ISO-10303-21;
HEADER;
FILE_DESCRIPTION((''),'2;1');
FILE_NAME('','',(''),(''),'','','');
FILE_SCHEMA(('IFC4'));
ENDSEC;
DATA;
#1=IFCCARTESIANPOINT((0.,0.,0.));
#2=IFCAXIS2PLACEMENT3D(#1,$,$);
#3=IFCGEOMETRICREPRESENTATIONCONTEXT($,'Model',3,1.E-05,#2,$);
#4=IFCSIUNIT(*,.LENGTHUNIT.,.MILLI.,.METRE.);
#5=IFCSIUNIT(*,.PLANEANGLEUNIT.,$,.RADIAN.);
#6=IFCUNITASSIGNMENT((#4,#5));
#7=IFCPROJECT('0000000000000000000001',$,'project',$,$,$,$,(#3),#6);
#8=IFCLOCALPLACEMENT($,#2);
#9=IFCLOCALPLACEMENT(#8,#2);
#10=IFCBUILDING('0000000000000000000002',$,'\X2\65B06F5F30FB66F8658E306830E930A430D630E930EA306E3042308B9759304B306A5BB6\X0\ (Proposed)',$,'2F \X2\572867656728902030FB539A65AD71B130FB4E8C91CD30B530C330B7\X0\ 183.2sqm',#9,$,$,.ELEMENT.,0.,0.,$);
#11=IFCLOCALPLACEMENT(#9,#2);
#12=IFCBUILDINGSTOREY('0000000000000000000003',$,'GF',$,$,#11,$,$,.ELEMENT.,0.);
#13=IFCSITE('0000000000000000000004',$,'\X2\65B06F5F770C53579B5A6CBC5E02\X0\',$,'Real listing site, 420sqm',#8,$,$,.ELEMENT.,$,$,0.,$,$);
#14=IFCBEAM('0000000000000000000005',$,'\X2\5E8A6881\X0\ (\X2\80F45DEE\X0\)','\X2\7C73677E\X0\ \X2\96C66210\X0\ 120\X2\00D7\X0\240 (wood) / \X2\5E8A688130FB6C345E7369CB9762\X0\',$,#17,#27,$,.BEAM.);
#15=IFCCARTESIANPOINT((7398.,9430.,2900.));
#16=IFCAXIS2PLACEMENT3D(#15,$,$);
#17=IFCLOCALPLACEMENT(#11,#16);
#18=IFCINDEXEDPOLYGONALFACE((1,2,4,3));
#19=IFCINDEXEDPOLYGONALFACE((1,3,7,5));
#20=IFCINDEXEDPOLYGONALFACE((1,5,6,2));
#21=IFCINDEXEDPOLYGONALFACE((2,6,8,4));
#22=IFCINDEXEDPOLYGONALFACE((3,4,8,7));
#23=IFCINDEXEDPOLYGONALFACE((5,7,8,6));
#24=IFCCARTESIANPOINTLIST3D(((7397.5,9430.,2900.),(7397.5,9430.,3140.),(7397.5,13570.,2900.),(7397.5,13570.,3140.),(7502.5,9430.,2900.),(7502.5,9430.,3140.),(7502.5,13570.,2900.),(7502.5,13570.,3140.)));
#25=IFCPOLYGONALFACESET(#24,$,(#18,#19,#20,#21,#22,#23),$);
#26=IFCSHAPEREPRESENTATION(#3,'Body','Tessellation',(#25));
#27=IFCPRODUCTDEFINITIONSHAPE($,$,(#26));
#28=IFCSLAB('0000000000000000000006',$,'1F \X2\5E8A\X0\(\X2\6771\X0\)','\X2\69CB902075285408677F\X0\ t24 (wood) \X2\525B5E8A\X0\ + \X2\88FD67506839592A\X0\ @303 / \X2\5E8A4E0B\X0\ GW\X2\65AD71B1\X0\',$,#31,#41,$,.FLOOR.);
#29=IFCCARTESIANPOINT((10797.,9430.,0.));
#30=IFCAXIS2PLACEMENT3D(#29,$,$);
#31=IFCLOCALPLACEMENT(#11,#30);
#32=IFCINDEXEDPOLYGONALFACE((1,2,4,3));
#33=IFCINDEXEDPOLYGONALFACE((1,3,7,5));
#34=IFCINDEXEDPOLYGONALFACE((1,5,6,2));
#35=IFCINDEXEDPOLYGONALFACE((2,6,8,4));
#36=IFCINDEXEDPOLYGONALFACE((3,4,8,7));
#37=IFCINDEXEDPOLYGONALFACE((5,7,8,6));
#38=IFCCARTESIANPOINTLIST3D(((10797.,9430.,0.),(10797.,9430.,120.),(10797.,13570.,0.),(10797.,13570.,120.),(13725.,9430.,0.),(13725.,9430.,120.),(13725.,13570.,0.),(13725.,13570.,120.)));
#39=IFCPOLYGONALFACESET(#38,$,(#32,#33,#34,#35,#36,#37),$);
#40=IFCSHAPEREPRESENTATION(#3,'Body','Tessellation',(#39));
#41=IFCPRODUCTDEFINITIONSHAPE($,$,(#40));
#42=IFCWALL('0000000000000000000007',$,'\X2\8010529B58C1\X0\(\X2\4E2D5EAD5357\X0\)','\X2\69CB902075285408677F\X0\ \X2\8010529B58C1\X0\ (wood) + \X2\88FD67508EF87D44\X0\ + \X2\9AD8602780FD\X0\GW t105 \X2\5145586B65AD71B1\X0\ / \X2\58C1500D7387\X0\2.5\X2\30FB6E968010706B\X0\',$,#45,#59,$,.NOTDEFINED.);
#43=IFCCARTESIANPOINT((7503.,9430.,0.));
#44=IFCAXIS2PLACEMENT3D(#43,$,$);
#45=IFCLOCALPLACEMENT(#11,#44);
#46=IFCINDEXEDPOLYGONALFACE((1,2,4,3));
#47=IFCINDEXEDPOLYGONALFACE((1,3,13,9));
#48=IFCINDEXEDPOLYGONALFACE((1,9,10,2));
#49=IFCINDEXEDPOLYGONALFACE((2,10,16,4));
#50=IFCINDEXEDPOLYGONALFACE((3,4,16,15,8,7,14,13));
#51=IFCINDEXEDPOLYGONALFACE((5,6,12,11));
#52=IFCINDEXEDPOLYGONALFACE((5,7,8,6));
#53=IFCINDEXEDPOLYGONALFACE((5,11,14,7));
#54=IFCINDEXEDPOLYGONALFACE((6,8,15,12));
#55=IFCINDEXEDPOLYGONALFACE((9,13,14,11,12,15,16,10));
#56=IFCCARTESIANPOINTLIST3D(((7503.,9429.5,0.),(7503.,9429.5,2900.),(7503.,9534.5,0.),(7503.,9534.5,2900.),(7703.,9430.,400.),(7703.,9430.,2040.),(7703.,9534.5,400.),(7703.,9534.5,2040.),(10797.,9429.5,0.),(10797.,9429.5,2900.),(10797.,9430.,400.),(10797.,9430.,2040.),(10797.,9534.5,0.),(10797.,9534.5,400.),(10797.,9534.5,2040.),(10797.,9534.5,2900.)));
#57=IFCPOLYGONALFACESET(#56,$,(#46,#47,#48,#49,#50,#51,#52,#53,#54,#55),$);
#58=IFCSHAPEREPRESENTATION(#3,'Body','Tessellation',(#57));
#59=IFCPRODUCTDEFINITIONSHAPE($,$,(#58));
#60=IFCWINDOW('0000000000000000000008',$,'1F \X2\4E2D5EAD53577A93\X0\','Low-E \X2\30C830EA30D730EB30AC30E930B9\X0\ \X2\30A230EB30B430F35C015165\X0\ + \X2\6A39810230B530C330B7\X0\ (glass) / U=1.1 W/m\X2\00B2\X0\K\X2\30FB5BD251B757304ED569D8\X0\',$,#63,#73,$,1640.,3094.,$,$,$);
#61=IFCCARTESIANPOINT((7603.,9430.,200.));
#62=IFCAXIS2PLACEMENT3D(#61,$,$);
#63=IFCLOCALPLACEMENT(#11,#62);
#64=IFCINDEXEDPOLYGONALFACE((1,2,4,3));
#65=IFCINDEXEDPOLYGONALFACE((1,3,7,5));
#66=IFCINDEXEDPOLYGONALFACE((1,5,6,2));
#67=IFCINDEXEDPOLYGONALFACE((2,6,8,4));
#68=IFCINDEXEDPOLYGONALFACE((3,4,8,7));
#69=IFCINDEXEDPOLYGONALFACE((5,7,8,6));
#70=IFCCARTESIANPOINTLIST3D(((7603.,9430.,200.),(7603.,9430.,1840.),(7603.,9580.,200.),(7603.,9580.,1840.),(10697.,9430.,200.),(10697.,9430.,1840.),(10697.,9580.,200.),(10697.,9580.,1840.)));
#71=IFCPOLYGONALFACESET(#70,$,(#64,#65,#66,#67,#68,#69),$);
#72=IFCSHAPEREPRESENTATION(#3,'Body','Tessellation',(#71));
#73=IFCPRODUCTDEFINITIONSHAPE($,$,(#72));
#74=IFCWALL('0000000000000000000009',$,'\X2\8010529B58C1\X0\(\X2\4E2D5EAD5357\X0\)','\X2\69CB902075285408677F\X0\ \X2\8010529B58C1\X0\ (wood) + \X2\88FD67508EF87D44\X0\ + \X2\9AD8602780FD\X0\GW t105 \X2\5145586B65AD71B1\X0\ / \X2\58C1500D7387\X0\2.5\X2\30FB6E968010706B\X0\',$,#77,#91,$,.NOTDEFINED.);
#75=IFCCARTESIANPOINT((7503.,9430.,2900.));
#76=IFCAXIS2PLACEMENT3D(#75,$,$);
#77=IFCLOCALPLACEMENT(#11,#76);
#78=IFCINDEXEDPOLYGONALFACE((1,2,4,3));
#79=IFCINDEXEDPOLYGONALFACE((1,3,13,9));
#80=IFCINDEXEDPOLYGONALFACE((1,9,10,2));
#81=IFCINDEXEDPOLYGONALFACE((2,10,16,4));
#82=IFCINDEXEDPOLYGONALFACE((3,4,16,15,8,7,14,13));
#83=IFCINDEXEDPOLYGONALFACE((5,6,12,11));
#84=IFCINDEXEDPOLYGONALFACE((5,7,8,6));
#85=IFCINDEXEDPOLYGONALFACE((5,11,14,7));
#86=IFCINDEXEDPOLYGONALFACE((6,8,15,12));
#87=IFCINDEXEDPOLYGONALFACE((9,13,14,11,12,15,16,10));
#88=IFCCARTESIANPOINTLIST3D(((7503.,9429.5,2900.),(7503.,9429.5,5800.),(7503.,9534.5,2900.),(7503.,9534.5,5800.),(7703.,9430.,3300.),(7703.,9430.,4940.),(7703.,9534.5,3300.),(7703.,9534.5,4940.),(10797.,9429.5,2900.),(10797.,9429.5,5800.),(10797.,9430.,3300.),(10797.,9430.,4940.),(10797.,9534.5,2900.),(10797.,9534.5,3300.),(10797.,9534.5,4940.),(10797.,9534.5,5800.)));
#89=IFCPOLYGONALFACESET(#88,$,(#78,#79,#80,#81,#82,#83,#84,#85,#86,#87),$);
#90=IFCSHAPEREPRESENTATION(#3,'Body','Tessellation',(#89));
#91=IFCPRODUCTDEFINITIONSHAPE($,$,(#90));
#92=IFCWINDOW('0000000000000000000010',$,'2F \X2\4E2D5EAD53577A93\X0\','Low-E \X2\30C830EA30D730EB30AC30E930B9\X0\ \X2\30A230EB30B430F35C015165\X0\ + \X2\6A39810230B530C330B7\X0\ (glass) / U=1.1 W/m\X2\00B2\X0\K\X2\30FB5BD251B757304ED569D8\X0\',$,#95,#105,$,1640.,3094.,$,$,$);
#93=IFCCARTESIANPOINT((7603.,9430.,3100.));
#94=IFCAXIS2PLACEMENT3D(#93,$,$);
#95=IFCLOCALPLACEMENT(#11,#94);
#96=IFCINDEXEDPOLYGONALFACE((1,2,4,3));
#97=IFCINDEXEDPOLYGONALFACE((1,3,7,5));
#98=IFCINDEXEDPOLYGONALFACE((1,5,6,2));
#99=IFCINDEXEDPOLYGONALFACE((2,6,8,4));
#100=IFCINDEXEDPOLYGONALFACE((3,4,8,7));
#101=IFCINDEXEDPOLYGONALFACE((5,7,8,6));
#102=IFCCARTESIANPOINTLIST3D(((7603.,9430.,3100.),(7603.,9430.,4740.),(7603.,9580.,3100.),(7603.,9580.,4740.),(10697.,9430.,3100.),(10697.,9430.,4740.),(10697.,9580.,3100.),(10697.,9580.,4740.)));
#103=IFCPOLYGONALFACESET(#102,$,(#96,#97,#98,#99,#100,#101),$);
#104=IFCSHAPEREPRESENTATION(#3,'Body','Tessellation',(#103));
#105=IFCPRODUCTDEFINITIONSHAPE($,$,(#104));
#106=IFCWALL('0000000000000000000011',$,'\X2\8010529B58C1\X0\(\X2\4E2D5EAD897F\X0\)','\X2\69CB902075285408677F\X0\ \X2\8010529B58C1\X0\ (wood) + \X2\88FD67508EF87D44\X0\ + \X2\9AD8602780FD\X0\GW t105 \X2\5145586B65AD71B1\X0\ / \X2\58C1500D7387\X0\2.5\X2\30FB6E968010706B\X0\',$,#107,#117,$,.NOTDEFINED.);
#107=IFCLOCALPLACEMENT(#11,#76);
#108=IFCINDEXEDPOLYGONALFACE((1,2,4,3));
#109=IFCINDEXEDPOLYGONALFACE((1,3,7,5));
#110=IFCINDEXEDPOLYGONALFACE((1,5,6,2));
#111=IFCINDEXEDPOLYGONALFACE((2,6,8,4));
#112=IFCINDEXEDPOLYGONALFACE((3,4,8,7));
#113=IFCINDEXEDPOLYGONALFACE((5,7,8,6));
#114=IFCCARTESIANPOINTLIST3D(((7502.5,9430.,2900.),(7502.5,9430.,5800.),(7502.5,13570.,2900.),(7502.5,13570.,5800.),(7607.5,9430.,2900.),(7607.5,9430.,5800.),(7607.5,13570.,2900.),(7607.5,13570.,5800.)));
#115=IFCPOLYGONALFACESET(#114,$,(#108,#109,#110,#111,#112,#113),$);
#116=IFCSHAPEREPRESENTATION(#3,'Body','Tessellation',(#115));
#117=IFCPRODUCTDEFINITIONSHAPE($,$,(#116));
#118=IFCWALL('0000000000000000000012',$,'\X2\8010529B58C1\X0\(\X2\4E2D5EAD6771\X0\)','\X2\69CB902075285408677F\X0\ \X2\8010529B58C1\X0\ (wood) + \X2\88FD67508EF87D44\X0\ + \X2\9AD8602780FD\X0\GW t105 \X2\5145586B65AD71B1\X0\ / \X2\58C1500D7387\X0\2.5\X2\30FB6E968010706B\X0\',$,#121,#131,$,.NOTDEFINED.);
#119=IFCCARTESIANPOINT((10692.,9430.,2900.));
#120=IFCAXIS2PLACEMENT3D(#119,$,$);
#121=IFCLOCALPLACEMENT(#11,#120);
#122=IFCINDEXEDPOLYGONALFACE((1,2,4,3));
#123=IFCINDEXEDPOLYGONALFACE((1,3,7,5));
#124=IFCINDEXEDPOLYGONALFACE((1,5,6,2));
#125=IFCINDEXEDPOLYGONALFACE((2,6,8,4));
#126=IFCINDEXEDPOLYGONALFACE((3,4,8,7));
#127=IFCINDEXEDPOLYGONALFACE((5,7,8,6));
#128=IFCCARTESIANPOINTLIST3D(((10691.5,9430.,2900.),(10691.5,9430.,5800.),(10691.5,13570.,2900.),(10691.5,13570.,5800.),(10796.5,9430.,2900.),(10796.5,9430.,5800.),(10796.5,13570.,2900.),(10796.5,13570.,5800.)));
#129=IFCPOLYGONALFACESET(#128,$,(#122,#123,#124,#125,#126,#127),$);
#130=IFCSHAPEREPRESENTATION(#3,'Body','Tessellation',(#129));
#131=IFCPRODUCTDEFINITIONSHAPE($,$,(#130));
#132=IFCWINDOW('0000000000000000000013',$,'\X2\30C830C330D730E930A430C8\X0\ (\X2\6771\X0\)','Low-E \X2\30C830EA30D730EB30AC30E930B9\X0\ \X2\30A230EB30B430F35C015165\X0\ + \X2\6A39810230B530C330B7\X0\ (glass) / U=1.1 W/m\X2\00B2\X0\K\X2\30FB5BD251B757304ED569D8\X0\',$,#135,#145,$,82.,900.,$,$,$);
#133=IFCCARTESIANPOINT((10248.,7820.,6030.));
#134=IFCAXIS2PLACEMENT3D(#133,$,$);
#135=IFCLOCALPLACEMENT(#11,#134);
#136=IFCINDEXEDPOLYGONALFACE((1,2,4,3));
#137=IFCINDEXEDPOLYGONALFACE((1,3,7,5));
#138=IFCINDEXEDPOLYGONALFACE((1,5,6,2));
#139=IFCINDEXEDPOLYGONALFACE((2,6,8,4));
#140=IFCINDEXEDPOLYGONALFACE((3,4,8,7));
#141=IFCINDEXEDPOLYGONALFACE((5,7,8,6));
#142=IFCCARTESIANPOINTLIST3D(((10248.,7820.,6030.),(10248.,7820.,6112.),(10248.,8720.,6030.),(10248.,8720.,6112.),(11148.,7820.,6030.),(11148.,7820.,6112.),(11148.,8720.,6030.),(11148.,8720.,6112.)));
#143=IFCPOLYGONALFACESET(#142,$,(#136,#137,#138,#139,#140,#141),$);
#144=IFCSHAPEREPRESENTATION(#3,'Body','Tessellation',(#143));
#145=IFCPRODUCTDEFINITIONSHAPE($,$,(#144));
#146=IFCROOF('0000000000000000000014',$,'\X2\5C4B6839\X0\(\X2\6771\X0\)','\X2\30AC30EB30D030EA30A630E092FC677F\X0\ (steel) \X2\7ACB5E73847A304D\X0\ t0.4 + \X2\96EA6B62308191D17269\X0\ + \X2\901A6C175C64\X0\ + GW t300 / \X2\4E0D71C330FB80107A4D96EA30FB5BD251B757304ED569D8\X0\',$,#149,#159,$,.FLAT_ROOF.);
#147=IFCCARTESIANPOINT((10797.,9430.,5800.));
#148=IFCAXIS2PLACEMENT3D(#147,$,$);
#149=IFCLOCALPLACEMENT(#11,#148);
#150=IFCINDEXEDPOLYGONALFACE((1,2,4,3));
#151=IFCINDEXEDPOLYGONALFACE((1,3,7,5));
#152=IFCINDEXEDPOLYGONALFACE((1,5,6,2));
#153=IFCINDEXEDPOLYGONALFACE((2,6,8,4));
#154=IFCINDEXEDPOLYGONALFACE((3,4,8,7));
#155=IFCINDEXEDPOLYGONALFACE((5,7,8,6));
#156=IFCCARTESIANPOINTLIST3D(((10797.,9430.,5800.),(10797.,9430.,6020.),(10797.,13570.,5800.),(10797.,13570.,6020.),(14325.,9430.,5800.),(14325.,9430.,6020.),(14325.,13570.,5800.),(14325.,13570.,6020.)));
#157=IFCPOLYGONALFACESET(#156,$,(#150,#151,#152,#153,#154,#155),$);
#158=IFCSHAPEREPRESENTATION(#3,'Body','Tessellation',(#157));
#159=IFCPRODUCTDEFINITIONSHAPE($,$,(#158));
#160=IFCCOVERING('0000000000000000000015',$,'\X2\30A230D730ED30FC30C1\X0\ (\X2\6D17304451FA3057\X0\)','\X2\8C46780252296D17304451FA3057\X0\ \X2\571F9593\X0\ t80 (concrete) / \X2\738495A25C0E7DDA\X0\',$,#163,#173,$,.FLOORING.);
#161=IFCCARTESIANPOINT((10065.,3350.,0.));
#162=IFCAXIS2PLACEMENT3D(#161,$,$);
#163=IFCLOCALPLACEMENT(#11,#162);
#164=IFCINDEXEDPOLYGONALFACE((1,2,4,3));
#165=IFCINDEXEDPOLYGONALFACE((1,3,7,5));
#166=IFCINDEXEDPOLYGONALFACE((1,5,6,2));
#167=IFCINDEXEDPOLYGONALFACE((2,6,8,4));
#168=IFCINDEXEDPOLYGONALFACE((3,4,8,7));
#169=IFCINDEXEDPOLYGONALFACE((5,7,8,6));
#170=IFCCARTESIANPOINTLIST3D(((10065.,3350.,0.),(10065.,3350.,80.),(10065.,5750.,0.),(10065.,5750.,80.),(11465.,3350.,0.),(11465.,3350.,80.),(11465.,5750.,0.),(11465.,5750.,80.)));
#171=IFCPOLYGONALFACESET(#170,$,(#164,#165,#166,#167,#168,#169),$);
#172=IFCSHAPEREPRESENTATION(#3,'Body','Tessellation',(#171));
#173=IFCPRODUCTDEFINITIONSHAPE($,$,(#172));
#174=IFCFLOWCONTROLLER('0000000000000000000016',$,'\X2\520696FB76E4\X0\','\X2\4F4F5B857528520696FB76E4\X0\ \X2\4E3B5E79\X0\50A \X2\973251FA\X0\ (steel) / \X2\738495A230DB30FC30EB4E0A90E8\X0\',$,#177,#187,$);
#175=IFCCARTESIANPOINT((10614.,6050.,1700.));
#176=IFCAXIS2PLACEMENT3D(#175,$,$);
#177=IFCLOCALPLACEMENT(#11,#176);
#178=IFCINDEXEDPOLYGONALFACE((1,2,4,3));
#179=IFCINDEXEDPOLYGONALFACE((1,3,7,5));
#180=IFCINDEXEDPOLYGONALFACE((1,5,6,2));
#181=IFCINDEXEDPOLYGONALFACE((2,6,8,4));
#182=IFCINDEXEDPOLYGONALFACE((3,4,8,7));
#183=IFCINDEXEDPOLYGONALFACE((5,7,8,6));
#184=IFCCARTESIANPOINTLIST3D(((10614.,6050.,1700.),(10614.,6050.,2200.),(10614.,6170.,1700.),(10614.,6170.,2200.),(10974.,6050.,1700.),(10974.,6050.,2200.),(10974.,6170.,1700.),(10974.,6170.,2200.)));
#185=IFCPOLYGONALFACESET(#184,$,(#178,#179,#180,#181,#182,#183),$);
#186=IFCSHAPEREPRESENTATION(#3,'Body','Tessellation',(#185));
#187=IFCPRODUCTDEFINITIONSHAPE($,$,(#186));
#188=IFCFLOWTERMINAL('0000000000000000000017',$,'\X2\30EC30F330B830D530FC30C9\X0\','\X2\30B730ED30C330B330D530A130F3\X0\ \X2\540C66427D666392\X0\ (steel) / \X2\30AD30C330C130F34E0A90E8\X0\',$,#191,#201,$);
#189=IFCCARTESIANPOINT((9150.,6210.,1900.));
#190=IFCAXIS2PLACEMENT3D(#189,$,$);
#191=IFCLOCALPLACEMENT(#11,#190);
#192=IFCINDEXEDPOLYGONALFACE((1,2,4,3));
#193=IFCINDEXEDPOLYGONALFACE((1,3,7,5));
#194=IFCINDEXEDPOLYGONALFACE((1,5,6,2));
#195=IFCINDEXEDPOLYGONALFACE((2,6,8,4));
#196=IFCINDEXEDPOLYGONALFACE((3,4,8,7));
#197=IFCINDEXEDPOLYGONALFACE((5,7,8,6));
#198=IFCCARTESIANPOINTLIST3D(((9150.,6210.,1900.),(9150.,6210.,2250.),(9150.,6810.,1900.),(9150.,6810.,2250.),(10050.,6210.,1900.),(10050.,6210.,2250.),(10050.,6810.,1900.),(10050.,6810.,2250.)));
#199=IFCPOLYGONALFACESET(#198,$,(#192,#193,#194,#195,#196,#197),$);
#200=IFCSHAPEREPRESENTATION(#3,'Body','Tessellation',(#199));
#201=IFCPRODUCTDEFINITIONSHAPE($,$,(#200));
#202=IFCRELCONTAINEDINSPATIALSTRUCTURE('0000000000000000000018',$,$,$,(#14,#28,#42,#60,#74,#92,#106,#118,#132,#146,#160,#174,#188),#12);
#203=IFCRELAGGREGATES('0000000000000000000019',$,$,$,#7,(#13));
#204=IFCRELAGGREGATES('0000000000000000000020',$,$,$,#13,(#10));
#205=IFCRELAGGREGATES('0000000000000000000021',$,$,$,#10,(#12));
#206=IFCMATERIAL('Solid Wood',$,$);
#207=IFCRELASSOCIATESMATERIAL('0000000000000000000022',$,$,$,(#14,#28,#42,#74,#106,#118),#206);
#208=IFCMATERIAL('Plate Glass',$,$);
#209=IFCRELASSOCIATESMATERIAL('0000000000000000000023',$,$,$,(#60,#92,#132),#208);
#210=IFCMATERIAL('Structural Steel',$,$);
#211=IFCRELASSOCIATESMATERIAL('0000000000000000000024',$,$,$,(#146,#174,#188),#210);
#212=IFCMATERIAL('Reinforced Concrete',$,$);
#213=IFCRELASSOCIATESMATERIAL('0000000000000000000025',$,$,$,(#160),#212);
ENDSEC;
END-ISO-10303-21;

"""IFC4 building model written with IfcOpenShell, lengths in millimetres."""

from ifc_helpers import new_model, si_unit, frame, frame_2d, origin, place, context, project, spatial, rectangle, extrude, material, element, fill, save


model = new_model("IFC4")

# Units and contexts
model_context = context("Model", 3, precision=1e-05, world=origin())
ifc_project = project(units=[si_unit("LENGTHUNIT", "METRE", prefix="MILLI"), si_unit("PLANEANGLEUNIT", "RADIAN")], contexts=[model_context])

# Site, building, storey
site_placement = place(None, origin())
site = spatial("IfcSite", under=ifc_project, at=site_placement, Name="新潟県南魚沼市", ObjectType="Real listing site, 420sqm", CompositionType="ELEMENT", RefElevation=0.0)
building_placement = place(site_placement, origin())
building = spatial("IfcBuilding", under=site, at=building_placement, Name="新潟・書斎とライブラリのある静かな家 (Proposed)", ObjectType="2F 在来木造・厚断熱・二重サッシ 183.2sqm", CompositionType="ELEMENT", ElevationOfRefHeight=0.0, ElevationOfTerrain=0.0)
storey_placement = place(building_placement, origin())
storey = spatial("IfcBuildingStorey", under=building, at=storey_placement, Name="GF", CompositionType="ELEMENT", Elevation=0.0)

# Shared definitions
ifc_material_1 = material(Name="Solid Wood")

# Beam
beam_placement = place(storey_placement, frame((7398.0, 9430.0, 2900.0)))
element("IfcBeam", 1, at=beam_placement, inside=storey, material=ifc_material_1, Name="床梁 (胴差)", Description="米松 集成 120×240 (wood) / 床梁・水平構面", PredefinedType="BEAM", context=model_context, shape_type="SweptSolid", body=[
    extrude(rectangle(XDim=105.0, YDim=4140.0, at=frame_2d((52.0, 2070.0))), frame((7398.0, 9430.0, 2900.0)), (0.0, 0.0, 1.0), 240.0),
])

# Slab
slab_placement = place(storey_placement, frame((10797.0, 9430.0, 0.0)))
element("IfcSlab", 2, at=slab_placement, inside=storey, material=ifc_material_1, Name="1F 床(東)", Description="構造用合板 t24 (wood) 剛床 + 製材根太 @303 / 床下 GW断熱", PredefinedType="FLOOR", context=model_context, shape_type="SweptSolid", body=[
    extrude(rectangle(XDim=2928.0, YDim=4140.0, at=frame_2d((1464.0, 2070.0))), frame((10797.0, 9430.0, 0.0)), (0.0, 0.0, 1.0), 120.0),
])

# Wall, opening, window
wall_1_placement = place(storey_placement, frame((7503.0, 9430.0, 0.0)))
wall_1 = element("IfcWall", 3, at=wall_1_placement, inside=storey, material=ifc_material_1, Name="耐力壁(中庭南)", Description="構造用合板 耐力壁 (wood) + 製材軸組 + 高性能GW t105 充填断熱 / 壁倍率2.5・準耐火", PredefinedType="NOTDEFINED", context=model_context, shape_type="SweptSolid", body=[
    extrude(rectangle(XDim=3294.0, YDim=105.0, at=frame_2d((1647.0, 52.0))), frame((7503.0, 9430.0, 0.0)), (0.0, 0.0, 1.0), 2900.0),
])
opening_1_placement = place(storey_placement, frame((7603.0, 9430.0, 200.0)))
opening_1 = element("IfcOpeningElement", 4, at=opening_1_placement, cuts=wall_1, PredefinedType="NOTDEFINED", context=model_context, shape_type="SweptSolid", body=[
    extrude(rectangle(XDim=3094.0, YDim=150.0, at=frame_2d((1547.0, 75.0))), frame((7603.0, 9430.0, 200.0)), (0.0, 0.0, 1.0), 1640.0),
])
ifc_material_2 = material(Name="Plate Glass")
window_1_placement = place(storey_placement, frame((7603.0, 9430.0, 200.0)))
window_1 = element("IfcWindow", 5, at=window_1_placement, inside=storey, material=ifc_material_2, Name="1F 中庭南窓", Description="Low-E トリプルガラス アルゴン封入 + 樹脂サッシ (glass) / U=1.1 W/m²K・寒冷地仕様", OverallHeight=1640.0, OverallWidth=3094.0, context=model_context, shape_type="SweptSolid", body=[
    extrude(rectangle(XDim=3094.0, YDim=150.0, at=frame_2d((1547.0, 75.0))), frame((7603.0, 9430.0, 200.0)), (0.0, 0.0, 1.0), 1640.0),
])
fill(opening_1, window_1)

# Wall, opening, window
wall_2_placement = place(storey_placement, frame((7503.0, 9430.0, 2900.0)))
wall_2 = element("IfcWall", 6, at=wall_2_placement, inside=storey, material=ifc_material_1, Name="耐力壁(中庭南)", Description="構造用合板 耐力壁 (wood) + 製材軸組 + 高性能GW t105 充填断熱 / 壁倍率2.5・準耐火", PredefinedType="NOTDEFINED", context=model_context, shape_type="SweptSolid", body=[
    extrude(rectangle(XDim=3294.0, YDim=105.0, at=frame_2d((1647.0, 52.0))), frame((7503.0, 9430.0, 2900.0)), (0.0, 0.0, 1.0), 2900.0),
])
opening_2_placement = place(storey_placement, frame((7603.0, 9430.0, 3100.0)))
opening_2 = element("IfcOpeningElement", 7, at=opening_2_placement, cuts=wall_2, PredefinedType="NOTDEFINED", context=model_context, shape_type="SweptSolid", body=[
    extrude(rectangle(XDim=3094.0, YDim=150.0, at=frame_2d((1547.0, 75.0))), frame((7603.0, 9430.0, 3100.0)), (0.0, 0.0, 1.0), 1640.0),
])
window_2_placement = place(storey_placement, frame((7603.0, 9430.0, 3100.0)))
window_2 = element("IfcWindow", 8, at=window_2_placement, inside=storey, material=ifc_material_2, Name="2F 中庭南窓", Description="Low-E トリプルガラス アルゴン封入 + 樹脂サッシ (glass) / U=1.1 W/m²K・寒冷地仕様", OverallHeight=1640.0, OverallWidth=3094.0, context=model_context, shape_type="SweptSolid", body=[
    extrude(rectangle(XDim=3094.0, YDim=150.0, at=frame_2d((1547.0, 75.0))), frame((7603.0, 9430.0, 3100.0)), (0.0, 0.0, 1.0), 1640.0),
])
fill(opening_2, window_2)

# Walls
wall_3_placement = place(storey_placement, frame((7503.0, 9430.0, 2900.0)))
element("IfcWall", 9, at=wall_3_placement, inside=storey, material=ifc_material_1, Name="耐力壁(中庭西)", Description="構造用合板 耐力壁 (wood) + 製材軸組 + 高性能GW t105 充填断熱 / 壁倍率2.5・準耐火", PredefinedType="NOTDEFINED", context=model_context, shape_type="SweptSolid", body=[
    extrude(rectangle(XDim=105.0, YDim=4140.0, at=frame_2d((52.0, 2070.0))), frame((7503.0, 9430.0, 2900.0)), (0.0, 0.0, 1.0), 2900.0),
])
wall_4_placement = place(storey_placement, frame((10692.0, 9430.0, 2900.0)))
element("IfcWall", 10, at=wall_4_placement, inside=storey, material=ifc_material_1, Name="耐力壁(中庭東)", Description="構造用合板 耐力壁 (wood) + 製材軸組 + 高性能GW t105 充填断熱 / 壁倍率2.5・準耐火", PredefinedType="NOTDEFINED", context=model_context, shape_type="SweptSolid", body=[
    extrude(rectangle(XDim=105.0, YDim=4140.0, at=frame_2d((52.0, 2070.0))), frame((10692.0, 9430.0, 2900.0)), (0.0, 0.0, 1.0), 2900.0),
])

# Window
window_3_placement = place(storey_placement, frame((10248.0, 7820.0, 6030.0)))
element("IfcWindow", 11, at=window_3_placement, inside=storey, material=ifc_material_2, Name="トップライト (東)", Description="Low-E トリプルガラス アルゴン封入 + 樹脂サッシ (glass) / U=1.1 W/m²K・寒冷地仕様", OverallHeight=82.0, OverallWidth=900.0, context=model_context, shape_type="SweptSolid", body=[
    extrude(rectangle(XDim=900.0, YDim=900.0, at=frame_2d((450.0, 450.0))), frame((10248.0, 7820.0, 6030.0)), (0.0, 0.0, 1.0), 82.0),
])

# Roof
ifc_material_3 = material(Name="Structural Steel")
roof_placement = place(storey_placement, frame((10797.0, 9430.0, 5800.0)))
element("IfcRoof", 12, at=roof_placement, inside=storey, material=ifc_material_3, Name="屋根(東)", Description="ガルバリウム鋼板 (steel) 立平葺き t0.4 + 雪止め金物 + 通気層 + GW t300 / 不燃・耐積雪・寒冷地仕様", PredefinedType="FLAT_ROOF", context=model_context, shape_type="SweptSolid", body=[
    extrude(rectangle(XDim=3528.0, YDim=4140.0, at=frame_2d((1764.0, 2070.0))), frame((10797.0, 9430.0, 5800.0)), (0.0, 0.0, 1.0), 220.0),
])

# Covering
ifc_material_4 = material(Name="Reinforced Concrete")
covering_placement = place(storey_placement, frame((10065.0, 3350.0, 0.0)))
element("IfcCovering", 13, at=covering_placement, inside=storey, material=ifc_material_4, Name="アプローチ (洗い出し)", Description="豆砂利洗い出し 土間 t80 (concrete) / 玄関導線", PredefinedType="FLOORING", context=model_context, shape_type="SweptSolid", body=[
    extrude(rectangle(XDim=1400.0, YDim=2400.0, at=frame_2d((700.0, 1200.0))), frame((10065.0, 3350.0, 0.0)), (0.0, 0.0, 1.0), 80.0),
])

# Flow controller
flow_controller_placement = place(storey_placement, frame((10614.0, 6050.0, 1700.0)))
element("IfcFlowController", 14, at=flow_controller_placement, inside=storey, material=ifc_material_3, Name="分電盤", Description="住宅用分電盤 主幹50A 露出 (steel) / 玄関ホール上部", context=model_context, shape_type="SweptSolid", body=[
    extrude(rectangle(XDim=360.0, YDim=120.0, at=frame_2d((180.0, 60.0))), frame((10614.0, 6050.0, 1700.0)), (0.0, 0.0, 1.0), 500.0),
])

# Flow terminal
flow_terminal_1_placement = place(storey_placement, frame((9150.0, 6210.0, 1900.0)))
element("IfcFlowTerminal", 15, at=flow_terminal_1_placement, inside=storey, material=ifc_material_3, Name="レンジフード", Description="シロッコファン 同時給排 (steel) / キッチン上部", context=model_context, shape_type="SweptSolid", body=[
    extrude(rectangle(XDim=900.0, YDim=600.0, at=frame_2d((450.0, 300.0))), frame((9150.0, 6210.0, 1900.0)), (0.0, 0.0, 1.0), 350.0),
])

save(model, "model.ifc")
